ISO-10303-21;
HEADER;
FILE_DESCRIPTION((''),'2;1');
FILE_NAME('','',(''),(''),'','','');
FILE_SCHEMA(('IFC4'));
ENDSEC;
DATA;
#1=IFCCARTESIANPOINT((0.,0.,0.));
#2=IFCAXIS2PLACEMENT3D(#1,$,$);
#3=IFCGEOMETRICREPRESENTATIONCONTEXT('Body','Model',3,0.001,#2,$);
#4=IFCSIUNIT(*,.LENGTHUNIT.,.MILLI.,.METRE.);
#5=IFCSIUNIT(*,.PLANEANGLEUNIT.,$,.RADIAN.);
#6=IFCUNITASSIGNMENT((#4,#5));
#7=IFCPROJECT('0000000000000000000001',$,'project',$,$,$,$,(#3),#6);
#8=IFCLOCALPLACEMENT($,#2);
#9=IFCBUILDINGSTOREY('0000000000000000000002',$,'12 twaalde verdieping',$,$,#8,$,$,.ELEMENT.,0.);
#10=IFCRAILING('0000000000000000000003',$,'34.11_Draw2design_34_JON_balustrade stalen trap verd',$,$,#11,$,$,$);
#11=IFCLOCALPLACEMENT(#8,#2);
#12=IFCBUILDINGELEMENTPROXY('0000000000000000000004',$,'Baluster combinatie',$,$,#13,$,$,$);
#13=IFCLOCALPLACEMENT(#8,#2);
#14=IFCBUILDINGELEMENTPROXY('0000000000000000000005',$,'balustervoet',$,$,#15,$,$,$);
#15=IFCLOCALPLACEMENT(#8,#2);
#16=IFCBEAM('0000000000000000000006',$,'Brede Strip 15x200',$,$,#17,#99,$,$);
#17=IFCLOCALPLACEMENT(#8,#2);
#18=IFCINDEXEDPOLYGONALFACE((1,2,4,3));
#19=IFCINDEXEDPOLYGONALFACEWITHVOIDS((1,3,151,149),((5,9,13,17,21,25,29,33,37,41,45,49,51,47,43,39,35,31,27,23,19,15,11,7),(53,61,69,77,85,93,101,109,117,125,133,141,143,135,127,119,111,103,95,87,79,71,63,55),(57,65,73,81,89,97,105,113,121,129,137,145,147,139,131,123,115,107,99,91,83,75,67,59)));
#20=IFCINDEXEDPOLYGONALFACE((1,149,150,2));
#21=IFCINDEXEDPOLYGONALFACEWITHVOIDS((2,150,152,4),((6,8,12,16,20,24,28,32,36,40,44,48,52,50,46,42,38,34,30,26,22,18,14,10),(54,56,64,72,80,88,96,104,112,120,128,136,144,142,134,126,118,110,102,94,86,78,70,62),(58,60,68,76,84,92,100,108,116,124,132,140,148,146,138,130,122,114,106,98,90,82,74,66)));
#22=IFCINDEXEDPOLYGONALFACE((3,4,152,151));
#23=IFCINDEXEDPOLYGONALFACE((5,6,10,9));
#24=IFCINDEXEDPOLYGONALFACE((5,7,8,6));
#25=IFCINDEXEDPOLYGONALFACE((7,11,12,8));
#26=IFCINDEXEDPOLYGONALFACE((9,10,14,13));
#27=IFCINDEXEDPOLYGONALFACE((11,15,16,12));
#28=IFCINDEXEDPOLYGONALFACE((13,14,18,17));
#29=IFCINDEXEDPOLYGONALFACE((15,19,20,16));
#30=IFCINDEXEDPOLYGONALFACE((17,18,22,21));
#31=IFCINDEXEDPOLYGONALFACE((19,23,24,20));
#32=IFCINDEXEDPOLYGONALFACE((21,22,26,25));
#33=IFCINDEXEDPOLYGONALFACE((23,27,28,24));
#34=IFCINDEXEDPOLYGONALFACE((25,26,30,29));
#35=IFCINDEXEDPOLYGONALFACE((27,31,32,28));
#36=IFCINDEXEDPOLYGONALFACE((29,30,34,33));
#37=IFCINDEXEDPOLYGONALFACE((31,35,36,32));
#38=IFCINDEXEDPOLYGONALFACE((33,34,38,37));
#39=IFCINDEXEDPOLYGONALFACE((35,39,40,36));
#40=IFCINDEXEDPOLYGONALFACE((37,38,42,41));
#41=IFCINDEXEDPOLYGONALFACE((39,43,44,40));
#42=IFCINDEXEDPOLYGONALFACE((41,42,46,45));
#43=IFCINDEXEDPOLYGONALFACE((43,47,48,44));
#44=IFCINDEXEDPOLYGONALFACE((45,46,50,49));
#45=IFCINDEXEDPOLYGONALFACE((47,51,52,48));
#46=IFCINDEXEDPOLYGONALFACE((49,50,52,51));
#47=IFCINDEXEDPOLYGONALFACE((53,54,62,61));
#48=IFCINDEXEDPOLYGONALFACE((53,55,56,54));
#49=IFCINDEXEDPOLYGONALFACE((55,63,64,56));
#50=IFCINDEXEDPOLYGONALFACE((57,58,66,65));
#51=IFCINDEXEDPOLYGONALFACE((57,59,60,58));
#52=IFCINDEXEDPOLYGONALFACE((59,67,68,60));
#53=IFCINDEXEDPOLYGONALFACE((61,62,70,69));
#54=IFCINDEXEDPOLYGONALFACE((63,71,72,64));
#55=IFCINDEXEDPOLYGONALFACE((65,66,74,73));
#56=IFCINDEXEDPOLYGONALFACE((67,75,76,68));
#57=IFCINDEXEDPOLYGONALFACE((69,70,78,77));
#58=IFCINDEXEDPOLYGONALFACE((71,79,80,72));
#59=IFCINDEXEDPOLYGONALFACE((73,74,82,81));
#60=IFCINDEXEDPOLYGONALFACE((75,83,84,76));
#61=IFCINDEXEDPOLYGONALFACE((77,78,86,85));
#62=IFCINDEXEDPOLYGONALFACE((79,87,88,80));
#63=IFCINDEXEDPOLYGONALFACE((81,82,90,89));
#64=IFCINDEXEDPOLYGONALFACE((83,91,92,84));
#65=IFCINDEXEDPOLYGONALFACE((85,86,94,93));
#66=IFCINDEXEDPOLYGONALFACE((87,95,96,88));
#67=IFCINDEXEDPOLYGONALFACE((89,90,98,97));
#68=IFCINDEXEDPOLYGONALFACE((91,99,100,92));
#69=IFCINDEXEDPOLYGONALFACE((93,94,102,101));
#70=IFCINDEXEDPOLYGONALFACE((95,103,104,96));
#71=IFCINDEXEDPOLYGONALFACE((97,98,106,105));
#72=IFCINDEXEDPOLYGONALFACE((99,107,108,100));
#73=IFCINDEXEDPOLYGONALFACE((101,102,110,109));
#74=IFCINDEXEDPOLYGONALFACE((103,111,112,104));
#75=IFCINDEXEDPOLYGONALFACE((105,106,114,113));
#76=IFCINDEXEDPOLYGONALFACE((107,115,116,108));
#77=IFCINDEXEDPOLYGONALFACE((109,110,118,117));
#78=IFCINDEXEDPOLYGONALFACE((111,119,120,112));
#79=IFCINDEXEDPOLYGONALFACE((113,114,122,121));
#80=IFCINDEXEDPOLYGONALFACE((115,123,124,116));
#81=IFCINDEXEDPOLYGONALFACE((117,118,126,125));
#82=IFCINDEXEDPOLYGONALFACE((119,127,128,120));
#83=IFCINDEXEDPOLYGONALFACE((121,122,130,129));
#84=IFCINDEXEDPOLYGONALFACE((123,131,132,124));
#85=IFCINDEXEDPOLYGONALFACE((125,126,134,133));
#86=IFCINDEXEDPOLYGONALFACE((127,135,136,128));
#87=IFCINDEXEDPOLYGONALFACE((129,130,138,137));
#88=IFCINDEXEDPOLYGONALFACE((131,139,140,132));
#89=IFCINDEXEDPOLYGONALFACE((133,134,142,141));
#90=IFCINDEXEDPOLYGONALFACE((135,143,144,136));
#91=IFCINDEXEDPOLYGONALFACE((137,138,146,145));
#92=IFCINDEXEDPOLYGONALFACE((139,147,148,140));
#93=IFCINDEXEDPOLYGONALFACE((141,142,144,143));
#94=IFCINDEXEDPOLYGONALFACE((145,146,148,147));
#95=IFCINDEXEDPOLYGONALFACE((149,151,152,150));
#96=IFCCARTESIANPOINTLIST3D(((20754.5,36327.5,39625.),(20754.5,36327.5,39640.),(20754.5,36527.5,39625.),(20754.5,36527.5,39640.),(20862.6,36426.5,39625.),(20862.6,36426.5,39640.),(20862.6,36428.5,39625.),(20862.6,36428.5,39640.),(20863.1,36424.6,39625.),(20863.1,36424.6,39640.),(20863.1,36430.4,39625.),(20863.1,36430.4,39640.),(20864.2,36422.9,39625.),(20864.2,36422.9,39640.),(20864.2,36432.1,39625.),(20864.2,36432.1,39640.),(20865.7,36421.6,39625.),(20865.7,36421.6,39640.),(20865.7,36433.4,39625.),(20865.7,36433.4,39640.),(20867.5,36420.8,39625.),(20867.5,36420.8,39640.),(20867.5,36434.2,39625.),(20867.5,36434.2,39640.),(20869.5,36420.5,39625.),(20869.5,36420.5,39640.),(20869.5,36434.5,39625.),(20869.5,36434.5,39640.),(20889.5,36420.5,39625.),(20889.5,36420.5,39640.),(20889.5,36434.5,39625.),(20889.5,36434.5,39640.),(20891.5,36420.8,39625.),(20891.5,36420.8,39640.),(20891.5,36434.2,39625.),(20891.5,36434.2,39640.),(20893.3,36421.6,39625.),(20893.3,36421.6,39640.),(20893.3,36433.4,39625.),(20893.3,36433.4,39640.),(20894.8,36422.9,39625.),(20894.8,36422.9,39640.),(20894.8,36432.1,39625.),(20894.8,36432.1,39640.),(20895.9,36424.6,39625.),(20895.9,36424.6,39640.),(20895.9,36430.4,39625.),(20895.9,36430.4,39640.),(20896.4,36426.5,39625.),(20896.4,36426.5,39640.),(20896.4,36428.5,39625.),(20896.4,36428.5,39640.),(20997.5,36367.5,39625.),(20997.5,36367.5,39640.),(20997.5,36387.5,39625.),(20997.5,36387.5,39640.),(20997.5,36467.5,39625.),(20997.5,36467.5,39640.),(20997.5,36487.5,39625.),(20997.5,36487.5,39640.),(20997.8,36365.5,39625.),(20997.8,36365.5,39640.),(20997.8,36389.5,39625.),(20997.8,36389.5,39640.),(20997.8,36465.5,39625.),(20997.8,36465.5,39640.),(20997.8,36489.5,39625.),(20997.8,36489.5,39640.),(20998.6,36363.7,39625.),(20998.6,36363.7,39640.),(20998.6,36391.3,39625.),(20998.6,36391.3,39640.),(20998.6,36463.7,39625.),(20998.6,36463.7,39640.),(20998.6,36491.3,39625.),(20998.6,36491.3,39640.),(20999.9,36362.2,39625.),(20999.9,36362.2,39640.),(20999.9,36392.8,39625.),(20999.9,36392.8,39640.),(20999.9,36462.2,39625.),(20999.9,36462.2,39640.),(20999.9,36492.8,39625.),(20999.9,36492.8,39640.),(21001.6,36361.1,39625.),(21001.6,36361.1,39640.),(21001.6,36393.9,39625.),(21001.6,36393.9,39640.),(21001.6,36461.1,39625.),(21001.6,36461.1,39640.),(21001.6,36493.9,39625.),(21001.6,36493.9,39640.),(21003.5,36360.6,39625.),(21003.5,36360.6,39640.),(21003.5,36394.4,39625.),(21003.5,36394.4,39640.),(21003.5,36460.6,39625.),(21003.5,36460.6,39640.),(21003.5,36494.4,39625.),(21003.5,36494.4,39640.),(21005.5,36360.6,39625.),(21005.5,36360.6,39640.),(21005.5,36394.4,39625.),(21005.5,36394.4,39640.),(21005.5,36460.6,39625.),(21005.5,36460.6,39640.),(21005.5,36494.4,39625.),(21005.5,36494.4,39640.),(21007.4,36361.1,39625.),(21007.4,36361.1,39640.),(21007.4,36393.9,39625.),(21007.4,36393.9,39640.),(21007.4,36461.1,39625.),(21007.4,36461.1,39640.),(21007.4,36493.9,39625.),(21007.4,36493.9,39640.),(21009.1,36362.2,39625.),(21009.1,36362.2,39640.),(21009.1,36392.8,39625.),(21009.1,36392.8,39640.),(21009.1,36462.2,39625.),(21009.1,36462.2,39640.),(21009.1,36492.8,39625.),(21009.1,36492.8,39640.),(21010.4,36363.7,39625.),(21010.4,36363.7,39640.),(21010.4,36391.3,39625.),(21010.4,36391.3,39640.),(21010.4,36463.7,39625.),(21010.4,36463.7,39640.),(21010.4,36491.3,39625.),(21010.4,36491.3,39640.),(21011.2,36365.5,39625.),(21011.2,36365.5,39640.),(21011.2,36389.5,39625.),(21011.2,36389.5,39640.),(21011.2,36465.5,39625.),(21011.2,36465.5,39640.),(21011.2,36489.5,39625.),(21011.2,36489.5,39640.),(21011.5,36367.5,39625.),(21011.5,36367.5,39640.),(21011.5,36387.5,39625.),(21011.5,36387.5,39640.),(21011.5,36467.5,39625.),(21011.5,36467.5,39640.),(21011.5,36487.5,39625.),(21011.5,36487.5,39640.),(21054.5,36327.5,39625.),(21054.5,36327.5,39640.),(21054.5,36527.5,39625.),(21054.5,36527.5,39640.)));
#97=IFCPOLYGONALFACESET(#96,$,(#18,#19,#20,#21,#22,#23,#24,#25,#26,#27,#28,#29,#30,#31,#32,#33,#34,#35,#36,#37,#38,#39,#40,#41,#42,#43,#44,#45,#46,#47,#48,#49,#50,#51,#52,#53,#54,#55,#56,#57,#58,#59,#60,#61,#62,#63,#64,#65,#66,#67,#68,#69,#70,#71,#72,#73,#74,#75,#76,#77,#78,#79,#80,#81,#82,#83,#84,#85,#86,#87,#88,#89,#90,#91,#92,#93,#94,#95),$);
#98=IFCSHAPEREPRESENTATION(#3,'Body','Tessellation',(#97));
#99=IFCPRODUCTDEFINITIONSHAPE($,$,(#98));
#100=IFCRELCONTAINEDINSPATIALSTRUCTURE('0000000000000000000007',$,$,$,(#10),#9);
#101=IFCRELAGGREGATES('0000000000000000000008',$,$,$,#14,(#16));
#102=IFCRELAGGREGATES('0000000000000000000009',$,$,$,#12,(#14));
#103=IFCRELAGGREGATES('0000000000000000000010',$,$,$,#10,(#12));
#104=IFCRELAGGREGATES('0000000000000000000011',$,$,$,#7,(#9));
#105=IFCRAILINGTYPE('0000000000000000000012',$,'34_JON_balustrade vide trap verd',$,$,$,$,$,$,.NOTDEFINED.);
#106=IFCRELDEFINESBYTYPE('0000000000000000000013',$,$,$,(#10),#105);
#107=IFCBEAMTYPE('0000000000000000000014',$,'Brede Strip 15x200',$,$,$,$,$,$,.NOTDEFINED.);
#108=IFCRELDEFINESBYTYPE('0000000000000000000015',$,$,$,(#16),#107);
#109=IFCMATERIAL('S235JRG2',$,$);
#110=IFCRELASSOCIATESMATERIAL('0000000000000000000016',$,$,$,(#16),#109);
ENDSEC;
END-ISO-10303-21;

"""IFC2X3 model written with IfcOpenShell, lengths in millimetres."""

from ifc_helpers import new_model, si_unit, point, frame, frame_2d, origin, origin_2d, place, context, project, spatial, circle_curve, line_curve, trimmed, segment, composite_curve, rectangle, outline, extrude, source, transform, mapped, material, type_object, element, aggregate, save


model = new_model("IFC2X3")

# Units and contexts
model_context = context("Model", 3, precision=0.001, world=origin(), identifier="Body")
ifc_project = project(units=[si_unit("LENGTHUNIT", "METRE", prefix="MILLI"), si_unit("PLANEANGLEUNIT", "RADIAN")], contexts=[model_context])

# Storey
storey_placement = place(None, origin())
storey = spatial("IfcBuildingStorey", under=ifc_project, at=storey_placement, Name="12 twaalde verdieping", CompositionType="ELEMENT", Elevation=0.0)

# Railing, building element proxies, beam, openings
railing_type = type_object("IfcRailingType", Name="34_JON_balustrade vide trap verd")
railing_placement = place(storey_placement, frame((-1939.6, -8072.1, 93983.6)))
railing = element("IfcRailing", 1, at=railing_placement, inside=storey, type_object=railing_type, Name="34.11_Draw2design_34_JON_balustrade stalen trap verd")
proxy_1_placement = place(railing_placement, frame((22994.2, 44834.6, -54348.6), z_axis=(0.0, 0.0, 1.0), x_axis=(0.0, 1.0, 0.0)))
proxy_1 = element("IfcBuildingElementProxy", 2, at=proxy_1_placement, Name="Baluster combinatie")
ifc_material_1 = material(Name="S235JRG2")
proxy_2_placement = place(proxy_1_placement, frame((-45247.5, 21054.5, -49235.0), z_axis=(0.0, 0.0, 1.0), x_axis=(0.0, -1.0, 0.0)))
proxy_2 = element("IfcBuildingElementProxy", 3, at=proxy_2_placement, Name="balustervoet")
beam_type_1 = type_object("IfcBeamType", Name="Brede Strip 15x200")
shared_shape_1 = source(origin(), model_context, "Body", "SweptSolid", [
    extrude(rectangle(XDim=15.0, YDim=200.0, at=origin_2d()), origin(), (0.0, 0.0, -1.0), 300.0),
])
beam_1_placement = place(proxy_2_placement, frame((21054.5, 44912.5, 49232.5), z_axis=(1.0, 0.0, 0.0), x_axis=(0.0, 0.0, 1.0)))
beam_1 = element("IfcBeam", 4, at=beam_1_placement, type_object=beam_type_1, material=ifc_material_1, Name="Brede Strip 15x200", context=model_context, shape_type="MappedRepresentation", body=[
    mapped(shared_shape_1, transform((0.0, 0.0, 0.0), scale=1.0)),
])
opening_1_placement = place(beam_1_placement, frame((7.5, 0.0, -175.0), z_axis=(-1.0, 0.0, 0.0), x_axis=(0.0, 0.0, -1.0)))
element("IfcOpeningElement", 5, at=opening_1_placement, cuts=beam_1, ObjectType="Opening", context=model_context, shape_type="SweptSolid", body=[
    extrude(outline(composite_curve([segment(trimmed(circle_curve(frame_2d((10.0, 0.0), x_axis=(0.0, -1.0)), 7.0), [point((10.0, 7.0))], [point((10.0, -7.0))], False, "CARTESIAN"), True, "CONTINUOUS"), segment(trimmed(line_curve((10.0, -7.0), (-20.0, 0.0), 20.0), [point((10.0, -7.0))], [point((-10.0, -7.0))], True, "CARTESIAN"), True, "CONTINUOUS"), segment(trimmed(circle_curve(frame_2d((-10.0, 0.0), x_axis=(0.0, -1.0)), 7.0), [point((-10.0, -7.0))], [point((-10.0, 7.0))], False, "CARTESIAN"), True, "CONTINUOUS"), segment(trimmed(line_curve((-10.0, 7.0), (20.0, 0.0), 20.0), [point((-10.0, 7.0))], [point((10.0, 7.0))], True, "CARTESIAN"), True, "CONTINUOUS")], self_intersect=False)), origin(), (0.0, 0.0, 1.0), 15.0),
])
opening_2_placement = place(beam_1_placement, frame((7.5, -50.0, -50.0), z_axis=(-1.0, 0.0, 0.0), x_axis=(0.0, -1.0, 0.0)))
element("IfcOpeningElement", 6, at=opening_2_placement, cuts=beam_1, ObjectType="Opening", context=model_context, shape_type="SweptSolid", body=[
    extrude(outline(composite_curve([segment(trimmed(circle_curve(frame_2d((10.0, 0.0), x_axis=(0.0, -1.0)), 7.0), [point((10.0, 7.0))], [point((10.0, -7.0))], False, "CARTESIAN"), True, "CONTINUOUS"), segment(trimmed(line_curve((10.0, -7.0), (-20.0, 0.0), 20.0), [point((10.0, -7.0))], [point((-10.0, -7.0))], True, "CARTESIAN"), True, "CONTINUOUS"), segment(trimmed(circle_curve(frame_2d((-10.0, 0.0), x_axis=(0.0, -1.0)), 7.0), [point((-10.0, -7.0))], [point((-10.0, 7.0))], False, "CARTESIAN"), True, "CONTINUOUS"), segment(trimmed(line_curve((-10.0, 7.0), (20.0, 0.0), 20.0), [point((-10.0, 7.0))], [point((10.0, 7.0))], True, "CARTESIAN"), True, "CONTINUOUS")], self_intersect=False)), origin(), (0.0, 0.0, 1.0), 15.0),
])
opening_3_placement = place(beam_1_placement, frame((7.5, 50.0, -50.0), z_axis=(-1.0, 0.0, 0.0), x_axis=(0.0, -1.0, 0.0)))
element("IfcOpeningElement", 7, at=opening_3_placement, cuts=beam_1, ObjectType="Opening", context=model_context, shape_type="SweptSolid", body=[
    extrude(outline(composite_curve([segment(trimmed(circle_curve(frame_2d((10.0, 0.0), x_axis=(0.0, -1.0)), 7.0), [point((10.0, 7.0))], [point((10.0, -7.0))], False, "CARTESIAN"), True, "CONTINUOUS"), segment(trimmed(line_curve((10.0, -7.0), (-20.0, 0.0), 20.0), [point((10.0, -7.0))], [point((-10.0, -7.0))], True, "CARTESIAN"), True, "CONTINUOUS"), segment(trimmed(circle_curve(frame_2d((-10.0, 0.0), x_axis=(0.0, -1.0)), 7.0), [point((-10.0, -7.0))], [point((-10.0, 7.0))], False, "CARTESIAN"), True, "CONTINUOUS"), segment(trimmed(line_curve((-10.0, 7.0), (20.0, 0.0), 20.0), [point((-10.0, 7.0))], [point((10.0, 7.0))], True, "CARTESIAN"), True, "CONTINUOUS")], self_intersect=False)), origin(), (0.0, 0.0, 1.0), 15.0),
])
aggregate(proxy_2, [beam_1])
aggregate(proxy_1, [proxy_2])
aggregate(railing, [proxy_1])

save(model, "model.ifc")
